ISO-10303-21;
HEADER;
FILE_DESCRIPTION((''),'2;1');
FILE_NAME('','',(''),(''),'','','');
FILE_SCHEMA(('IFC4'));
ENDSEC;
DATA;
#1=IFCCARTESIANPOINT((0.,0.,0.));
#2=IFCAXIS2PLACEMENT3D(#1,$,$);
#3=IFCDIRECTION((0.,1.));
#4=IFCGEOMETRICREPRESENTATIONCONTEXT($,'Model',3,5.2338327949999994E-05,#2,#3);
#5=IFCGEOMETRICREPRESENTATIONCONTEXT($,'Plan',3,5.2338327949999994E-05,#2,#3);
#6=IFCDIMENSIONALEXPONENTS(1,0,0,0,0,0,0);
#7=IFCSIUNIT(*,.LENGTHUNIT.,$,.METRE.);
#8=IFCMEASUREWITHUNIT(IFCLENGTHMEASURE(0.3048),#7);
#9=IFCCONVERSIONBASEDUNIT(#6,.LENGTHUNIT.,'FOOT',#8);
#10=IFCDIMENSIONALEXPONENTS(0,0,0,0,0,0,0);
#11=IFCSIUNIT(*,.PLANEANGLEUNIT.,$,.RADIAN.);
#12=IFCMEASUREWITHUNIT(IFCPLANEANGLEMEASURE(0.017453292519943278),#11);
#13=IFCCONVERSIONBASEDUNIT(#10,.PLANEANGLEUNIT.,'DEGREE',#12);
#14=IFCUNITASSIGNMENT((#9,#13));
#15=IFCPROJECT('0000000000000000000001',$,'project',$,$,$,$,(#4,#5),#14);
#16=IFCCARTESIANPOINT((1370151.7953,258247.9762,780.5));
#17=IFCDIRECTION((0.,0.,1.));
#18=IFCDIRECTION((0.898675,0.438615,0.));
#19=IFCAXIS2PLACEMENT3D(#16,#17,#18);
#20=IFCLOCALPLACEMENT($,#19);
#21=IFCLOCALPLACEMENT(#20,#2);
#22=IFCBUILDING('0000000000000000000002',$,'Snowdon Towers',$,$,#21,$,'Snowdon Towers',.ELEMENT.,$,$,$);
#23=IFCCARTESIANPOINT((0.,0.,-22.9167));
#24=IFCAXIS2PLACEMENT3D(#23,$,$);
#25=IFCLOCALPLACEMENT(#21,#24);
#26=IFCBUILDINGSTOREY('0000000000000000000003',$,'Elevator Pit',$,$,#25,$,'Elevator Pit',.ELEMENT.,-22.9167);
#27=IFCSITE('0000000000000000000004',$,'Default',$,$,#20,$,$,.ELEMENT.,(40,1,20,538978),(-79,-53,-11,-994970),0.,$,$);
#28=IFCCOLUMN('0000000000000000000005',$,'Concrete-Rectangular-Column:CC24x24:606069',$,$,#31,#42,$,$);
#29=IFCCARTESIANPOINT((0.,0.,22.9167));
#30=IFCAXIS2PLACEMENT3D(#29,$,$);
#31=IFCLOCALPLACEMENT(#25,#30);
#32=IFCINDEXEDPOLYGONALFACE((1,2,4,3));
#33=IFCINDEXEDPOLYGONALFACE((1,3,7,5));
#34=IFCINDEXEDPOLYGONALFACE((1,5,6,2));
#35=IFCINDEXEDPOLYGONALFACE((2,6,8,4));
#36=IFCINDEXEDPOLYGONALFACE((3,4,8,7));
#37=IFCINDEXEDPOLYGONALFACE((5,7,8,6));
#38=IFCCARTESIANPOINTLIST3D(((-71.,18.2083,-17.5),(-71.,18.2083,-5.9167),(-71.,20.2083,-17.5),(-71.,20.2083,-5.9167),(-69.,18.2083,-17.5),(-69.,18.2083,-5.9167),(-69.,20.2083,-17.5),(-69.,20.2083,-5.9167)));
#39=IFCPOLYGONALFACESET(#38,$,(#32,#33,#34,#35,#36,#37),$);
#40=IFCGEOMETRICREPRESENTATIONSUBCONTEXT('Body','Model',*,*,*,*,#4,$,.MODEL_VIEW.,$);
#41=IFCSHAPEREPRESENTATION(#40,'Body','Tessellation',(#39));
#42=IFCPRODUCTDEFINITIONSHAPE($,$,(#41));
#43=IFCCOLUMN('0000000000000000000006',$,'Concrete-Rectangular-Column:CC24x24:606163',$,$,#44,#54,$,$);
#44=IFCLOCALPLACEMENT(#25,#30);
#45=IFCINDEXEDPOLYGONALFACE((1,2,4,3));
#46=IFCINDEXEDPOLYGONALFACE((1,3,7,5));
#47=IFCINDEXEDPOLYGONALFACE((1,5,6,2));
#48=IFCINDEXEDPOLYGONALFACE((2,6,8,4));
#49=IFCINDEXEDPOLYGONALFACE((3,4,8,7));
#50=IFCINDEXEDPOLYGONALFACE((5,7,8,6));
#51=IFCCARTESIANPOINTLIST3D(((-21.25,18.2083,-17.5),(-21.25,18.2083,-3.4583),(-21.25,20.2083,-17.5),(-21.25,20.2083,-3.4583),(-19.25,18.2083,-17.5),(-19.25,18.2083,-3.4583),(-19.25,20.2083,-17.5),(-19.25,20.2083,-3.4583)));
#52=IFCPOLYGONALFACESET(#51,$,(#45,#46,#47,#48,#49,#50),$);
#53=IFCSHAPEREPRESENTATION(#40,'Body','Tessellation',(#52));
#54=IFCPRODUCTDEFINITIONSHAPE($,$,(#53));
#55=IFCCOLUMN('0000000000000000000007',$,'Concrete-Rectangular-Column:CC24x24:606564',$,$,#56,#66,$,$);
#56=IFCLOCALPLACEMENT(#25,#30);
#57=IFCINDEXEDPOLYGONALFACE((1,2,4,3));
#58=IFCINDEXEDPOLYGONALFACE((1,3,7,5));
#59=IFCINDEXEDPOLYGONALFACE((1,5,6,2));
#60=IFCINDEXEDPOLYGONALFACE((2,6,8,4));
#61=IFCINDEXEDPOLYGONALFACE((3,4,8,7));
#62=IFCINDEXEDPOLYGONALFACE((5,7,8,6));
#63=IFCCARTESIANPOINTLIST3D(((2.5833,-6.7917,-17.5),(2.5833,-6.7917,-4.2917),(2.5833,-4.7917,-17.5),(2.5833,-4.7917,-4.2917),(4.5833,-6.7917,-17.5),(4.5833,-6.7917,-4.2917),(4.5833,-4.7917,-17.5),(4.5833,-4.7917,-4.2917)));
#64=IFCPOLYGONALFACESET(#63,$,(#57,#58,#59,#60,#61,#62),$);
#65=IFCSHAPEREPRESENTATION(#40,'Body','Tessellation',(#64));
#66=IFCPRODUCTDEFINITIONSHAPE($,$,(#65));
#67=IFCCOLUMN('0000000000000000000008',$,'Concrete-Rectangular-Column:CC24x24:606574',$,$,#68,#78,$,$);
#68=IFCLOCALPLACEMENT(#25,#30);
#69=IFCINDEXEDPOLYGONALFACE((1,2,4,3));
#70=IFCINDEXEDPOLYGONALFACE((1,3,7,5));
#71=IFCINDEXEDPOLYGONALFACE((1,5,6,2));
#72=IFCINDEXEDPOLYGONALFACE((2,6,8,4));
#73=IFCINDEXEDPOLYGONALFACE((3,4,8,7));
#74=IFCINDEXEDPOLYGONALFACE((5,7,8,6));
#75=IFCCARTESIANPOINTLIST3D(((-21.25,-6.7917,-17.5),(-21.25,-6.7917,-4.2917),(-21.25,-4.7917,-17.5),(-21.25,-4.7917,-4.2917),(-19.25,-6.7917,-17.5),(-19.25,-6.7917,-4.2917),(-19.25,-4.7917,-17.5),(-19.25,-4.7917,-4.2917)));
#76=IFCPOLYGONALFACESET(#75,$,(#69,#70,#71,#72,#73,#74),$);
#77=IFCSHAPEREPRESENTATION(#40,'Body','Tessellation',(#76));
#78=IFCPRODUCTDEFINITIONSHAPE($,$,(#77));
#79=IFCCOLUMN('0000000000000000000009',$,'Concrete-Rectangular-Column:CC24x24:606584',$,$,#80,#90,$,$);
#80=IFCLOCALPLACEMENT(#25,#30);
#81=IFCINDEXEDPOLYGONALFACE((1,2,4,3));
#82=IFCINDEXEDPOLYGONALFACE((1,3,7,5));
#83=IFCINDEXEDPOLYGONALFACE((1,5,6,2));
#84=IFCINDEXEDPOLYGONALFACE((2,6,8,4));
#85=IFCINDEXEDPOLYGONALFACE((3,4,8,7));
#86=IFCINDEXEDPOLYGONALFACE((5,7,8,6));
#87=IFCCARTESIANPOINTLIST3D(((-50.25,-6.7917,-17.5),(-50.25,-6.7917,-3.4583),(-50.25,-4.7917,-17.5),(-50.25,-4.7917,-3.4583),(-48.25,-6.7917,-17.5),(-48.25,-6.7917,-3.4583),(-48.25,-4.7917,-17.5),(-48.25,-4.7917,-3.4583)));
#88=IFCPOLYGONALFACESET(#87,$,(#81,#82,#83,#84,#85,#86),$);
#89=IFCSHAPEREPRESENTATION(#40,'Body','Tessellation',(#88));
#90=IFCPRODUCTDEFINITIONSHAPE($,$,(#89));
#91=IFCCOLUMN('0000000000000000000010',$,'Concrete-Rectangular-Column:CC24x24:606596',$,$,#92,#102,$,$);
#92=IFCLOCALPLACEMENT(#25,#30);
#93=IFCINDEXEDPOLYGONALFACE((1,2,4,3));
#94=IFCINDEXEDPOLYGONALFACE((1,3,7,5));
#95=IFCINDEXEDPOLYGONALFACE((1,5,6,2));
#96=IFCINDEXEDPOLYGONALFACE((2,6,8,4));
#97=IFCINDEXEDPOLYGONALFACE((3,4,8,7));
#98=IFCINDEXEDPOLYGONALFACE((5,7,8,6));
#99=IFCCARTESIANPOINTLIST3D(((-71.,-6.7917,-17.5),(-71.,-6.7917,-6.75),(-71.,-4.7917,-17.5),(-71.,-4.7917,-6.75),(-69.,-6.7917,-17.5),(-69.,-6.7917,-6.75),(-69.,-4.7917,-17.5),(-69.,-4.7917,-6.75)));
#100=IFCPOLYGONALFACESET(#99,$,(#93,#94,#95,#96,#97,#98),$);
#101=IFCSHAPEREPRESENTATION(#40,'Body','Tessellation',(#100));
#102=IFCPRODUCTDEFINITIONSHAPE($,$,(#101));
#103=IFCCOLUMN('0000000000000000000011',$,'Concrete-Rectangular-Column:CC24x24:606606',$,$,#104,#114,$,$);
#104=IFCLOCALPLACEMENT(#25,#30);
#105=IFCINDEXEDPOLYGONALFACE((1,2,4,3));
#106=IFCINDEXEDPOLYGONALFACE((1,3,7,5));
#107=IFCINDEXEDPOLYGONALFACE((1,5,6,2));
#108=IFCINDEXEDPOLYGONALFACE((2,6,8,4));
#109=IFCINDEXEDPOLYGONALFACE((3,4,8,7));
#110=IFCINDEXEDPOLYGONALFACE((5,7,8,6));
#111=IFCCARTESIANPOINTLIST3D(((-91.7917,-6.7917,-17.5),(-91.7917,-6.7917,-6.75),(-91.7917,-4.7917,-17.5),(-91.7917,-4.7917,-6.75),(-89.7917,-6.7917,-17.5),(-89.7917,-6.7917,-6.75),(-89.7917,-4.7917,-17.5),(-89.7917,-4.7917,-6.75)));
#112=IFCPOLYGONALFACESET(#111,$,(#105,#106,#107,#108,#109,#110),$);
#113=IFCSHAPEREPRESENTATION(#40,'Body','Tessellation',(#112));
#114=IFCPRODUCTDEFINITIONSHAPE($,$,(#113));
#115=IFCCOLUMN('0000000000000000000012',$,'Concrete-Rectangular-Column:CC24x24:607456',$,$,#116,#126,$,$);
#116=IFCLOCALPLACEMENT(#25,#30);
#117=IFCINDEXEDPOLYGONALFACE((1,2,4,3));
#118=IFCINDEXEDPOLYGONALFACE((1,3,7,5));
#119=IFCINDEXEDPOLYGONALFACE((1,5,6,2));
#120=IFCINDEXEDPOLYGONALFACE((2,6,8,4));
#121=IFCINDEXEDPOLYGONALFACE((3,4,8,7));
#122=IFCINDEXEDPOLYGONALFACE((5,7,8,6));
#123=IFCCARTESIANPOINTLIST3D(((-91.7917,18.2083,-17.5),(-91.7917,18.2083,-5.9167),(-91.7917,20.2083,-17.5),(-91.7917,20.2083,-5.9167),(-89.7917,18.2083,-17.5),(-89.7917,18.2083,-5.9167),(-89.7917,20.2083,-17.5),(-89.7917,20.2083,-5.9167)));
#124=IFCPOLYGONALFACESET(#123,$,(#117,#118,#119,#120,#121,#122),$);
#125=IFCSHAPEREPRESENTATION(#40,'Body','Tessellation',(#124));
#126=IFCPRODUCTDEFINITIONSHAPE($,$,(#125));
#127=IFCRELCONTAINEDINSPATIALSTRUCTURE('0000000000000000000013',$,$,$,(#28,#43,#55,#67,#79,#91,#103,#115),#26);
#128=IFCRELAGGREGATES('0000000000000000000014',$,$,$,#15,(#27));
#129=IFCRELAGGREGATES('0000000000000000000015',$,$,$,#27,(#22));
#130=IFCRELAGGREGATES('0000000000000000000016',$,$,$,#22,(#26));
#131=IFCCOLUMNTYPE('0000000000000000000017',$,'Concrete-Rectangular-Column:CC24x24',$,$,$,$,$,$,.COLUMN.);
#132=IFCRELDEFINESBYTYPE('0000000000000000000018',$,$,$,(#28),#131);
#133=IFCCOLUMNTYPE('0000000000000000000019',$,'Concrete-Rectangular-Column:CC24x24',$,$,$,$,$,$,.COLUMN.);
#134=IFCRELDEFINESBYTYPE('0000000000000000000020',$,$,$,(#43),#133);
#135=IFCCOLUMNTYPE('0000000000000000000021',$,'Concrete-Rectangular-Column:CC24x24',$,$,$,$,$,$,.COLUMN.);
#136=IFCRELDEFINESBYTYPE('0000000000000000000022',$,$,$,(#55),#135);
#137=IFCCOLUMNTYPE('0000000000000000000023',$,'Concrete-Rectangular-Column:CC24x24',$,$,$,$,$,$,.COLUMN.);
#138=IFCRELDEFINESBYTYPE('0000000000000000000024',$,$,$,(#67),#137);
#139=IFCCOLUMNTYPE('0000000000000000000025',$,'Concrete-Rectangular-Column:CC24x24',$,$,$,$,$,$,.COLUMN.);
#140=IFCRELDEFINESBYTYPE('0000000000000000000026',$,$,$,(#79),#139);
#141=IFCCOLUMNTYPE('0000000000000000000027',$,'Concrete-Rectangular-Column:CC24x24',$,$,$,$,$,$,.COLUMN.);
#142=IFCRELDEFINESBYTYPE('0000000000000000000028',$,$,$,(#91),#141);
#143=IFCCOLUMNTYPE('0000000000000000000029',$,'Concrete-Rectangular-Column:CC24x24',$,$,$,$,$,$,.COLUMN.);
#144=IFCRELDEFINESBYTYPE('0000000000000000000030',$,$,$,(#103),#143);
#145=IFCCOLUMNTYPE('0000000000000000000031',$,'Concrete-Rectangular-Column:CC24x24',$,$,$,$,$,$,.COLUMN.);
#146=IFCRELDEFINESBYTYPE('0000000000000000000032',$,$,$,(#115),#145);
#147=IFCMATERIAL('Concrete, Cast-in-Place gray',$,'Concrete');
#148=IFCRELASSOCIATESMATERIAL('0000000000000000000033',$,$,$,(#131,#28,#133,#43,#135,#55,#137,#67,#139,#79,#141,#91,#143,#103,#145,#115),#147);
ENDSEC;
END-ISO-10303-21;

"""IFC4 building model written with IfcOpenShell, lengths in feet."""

from ifc_helpers import new_model, entity, si_unit, converted_unit, direction, frame, origin, place, context, subcontext, project, spatial, indexed_curve, outline, extrude, source, transform, mapped, material, type_object, type_shapes, element, save


model = new_model("IFC4")

# Units and contexts
model_context = context("Model", 3, precision=5.2338327949999994e-05, world=origin(), true_north=direction((0.0, 1.0)))
plan_context = context("Plan", 3, precision=5.2338327949999994e-05, world=origin(), true_north=direction((0.0, 1.0)))
body_context = subcontext(model_context, "Body", "Model", "MODEL_VIEW")
ifc_project = project(units=[converted_unit("LENGTHUNIT", "FOOT", entity("IfcLengthMeasure", 0.3048), si_unit("LENGTHUNIT", "METRE"), dimensions=[1, 0, 0, 0, 0, 0, 0]), converted_unit("PLANEANGLEUNIT", "DEGREE", entity("IfcPlaneAngleMeasure", 0.017453292519943278), si_unit("PLANEANGLEUNIT", "RADIAN"), dimensions=[0, 0, 0, 0, 0, 0, 0])], contexts=[model_context, plan_context])

# Site, building, storey
site_placement = place(None, frame((1370151.7953, 258247.9762, 780.5), z_axis=(0.0, 0.0, 1.0), x_axis=(0.898675, 0.438615, 0.0)))
site = spatial("IfcSite", under=ifc_project, at=site_placement, Name="Default", CompositionType="ELEMENT", RefLatitude=(40, 1, 20, 538978), RefLongitude=(-79, -53, -11, -994970), RefElevation=0.0)
building_placement = place(site_placement, origin())
building = spatial("IfcBuilding", under=site, at=building_placement, Name="Snowdon Towers", LongName="Snowdon Towers", CompositionType="ELEMENT")
storey_placement = place(building_placement, frame((0.0, 0.0, -22.9167)))
storey = spatial("IfcBuildingStorey", under=building, at=storey_placement, Name="Elevator Pit", LongName="Elevator Pit", CompositionType="ELEMENT", Elevation=-22.9167)

# Columns
ifc_material = material(Name="Concrete, Cast-in-Place gray", Category="Concrete")
column_type_1 = type_object("IfcColumnType", Name="Concrete-Rectangular-Column:CC24x24", PredefinedType="COLUMN", material=ifc_material)
shared_shape_1 = source(origin(), body_context, "Body", "SweptSolid", [
    extrude(outline(indexed_curve([(-1.0, -1.0), (1.0, -1.0), (1.0, 1.0), (-1.0, 1.0), (-1.0, -1.0)], self_intersect=False)), frame((-70.0, 19.2083, -17.5), z_axis=(0.0, 0.0, 1.0), x_axis=(-1.0, 0.0, 0.0)), (0.0, 0.0, 1.0), 11.5833),
])
type_shapes(column_type_1, [shared_shape_1])
column_1_placement = place(storey_placement, frame((0.0, 0.0, 22.9167)))
element("IfcColumn", 1, at=column_1_placement, inside=storey, type_object=column_type_1, material=ifc_material, Name="Concrete-Rectangular-Column:CC24x24:606069", context=body_context, shape_type="MappedRepresentation", body=[
    mapped(shared_shape_1, transform((0.0, 0.0, 0.0), scale=1.0)),
])
column_type_2 = type_object("IfcColumnType", Name="Concrete-Rectangular-Column:CC24x24", PredefinedType="COLUMN", material=ifc_material)
shared_shape_2 = source(origin(), body_context, "Body", "SweptSolid", [
    extrude(outline(indexed_curve([(-1.0, -1.0), (1.0, -1.0), (1.0, 1.0), (-1.0, 1.0), (-1.0, -1.0)], self_intersect=False)), frame((-20.25, 19.2083, -17.5), z_axis=(0.0, 0.0, 1.0), x_axis=(-1.0, 0.0, 0.0)), (0.0, 0.0, 1.0), 14.0417),
])
type_shapes(column_type_2, [shared_shape_2])
column_2_placement = place(storey_placement, frame((0.0, 0.0, 22.9167)))
element("IfcColumn", 2, at=column_2_placement, inside=storey, type_object=column_type_2, material=ifc_material, Name="Concrete-Rectangular-Column:CC24x24:606163", context=body_context, shape_type="MappedRepresentation", body=[
    mapped(shared_shape_2, transform((0.0, 0.0, 0.0), scale=1.0)),
])
column_type_3 = type_object("IfcColumnType", Name="Concrete-Rectangular-Column:CC24x24", PredefinedType="COLUMN", material=ifc_material)
shared_shape_3 = source(origin(), body_context, "Body", "SweptSolid", [
    extrude(outline(indexed_curve([(-1.0, -1.0), (1.0, -1.0), (1.0, 1.0), (-1.0, 1.0), (-1.0, -1.0)], self_intersect=False)), frame((3.5833, -5.7917, -17.5), z_axis=(0.0, 0.0, 1.0), x_axis=(-1.0, 0.0, 0.0)), (0.0, 0.0, 1.0), 13.2083),
])
type_shapes(column_type_3, [shared_shape_3])
column_3_placement = place(storey_placement, frame((0.0, 0.0, 22.9167)))
element("IfcColumn", 3, at=column_3_placement, inside=storey, type_object=column_type_3, material=ifc_material, Name="Concrete-Rectangular-Column:CC24x24:606564", context=body_context, shape_type="MappedRepresentation", body=[
    mapped(shared_shape_3, transform((0.0, 0.0, 0.0), scale=1.0)),
])
column_type_4 = type_object("IfcColumnType", Name="Concrete-Rectangular-Column:CC24x24", PredefinedType="COLUMN", material=ifc_material)
shared_shape_4 = source(origin(), body_context, "Body", "SweptSolid", [
    extrude(outline(indexed_curve([(-1.0, -1.0), (1.0, -1.0), (1.0, 1.0), (-1.0, 1.0), (-1.0, -1.0)], self_intersect=False)), frame((-20.25, -5.7917, -17.5), z_axis=(0.0, 0.0, 1.0), x_axis=(-1.0, 0.0, 0.0)), (0.0, 0.0, 1.0), 13.2083),
])
type_shapes(column_type_4, [shared_shape_4])
column_4_placement = place(storey_placement, frame((0.0, 0.0, 22.9167)))
element("IfcColumn", 4, at=column_4_placement, inside=storey, type_object=column_type_4, material=ifc_material, Name="Concrete-Rectangular-Column:CC24x24:606574", context=body_context, shape_type="MappedRepresentation", body=[
    mapped(shared_shape_4, transform((0.0, 0.0, 0.0), scale=1.0)),
])
column_type_5 = type_object("IfcColumnType", Name="Concrete-Rectangular-Column:CC24x24", PredefinedType="COLUMN", material=ifc_material)
shared_shape_5 = source(origin(), body_context, "Body", "SweptSolid", [
    extrude(outline(indexed_curve([(-1.0, -1.0), (1.0, -1.0), (1.0, 1.0), (-1.0, 1.0), (-1.0, -1.0)], self_intersect=False)), frame((-49.25, -5.7917, -17.5), z_axis=(0.0, 0.0, 1.0), x_axis=(-1.0, 0.0, 0.0)), (0.0, 0.0, 1.0), 14.0417),
])
type_shapes(column_type_5, [shared_shape_5])
column_5_placement = place(storey_placement, frame((0.0, 0.0, 22.9167)))
element("IfcColumn", 5, at=column_5_placement, inside=storey, type_object=column_type_5, material=ifc_material, Name="Concrete-Rectangular-Column:CC24x24:606584", context=body_context, shape_type="MappedRepresentation", body=[
    mapped(shared_shape_5, transform((0.0, 0.0, 0.0), scale=1.0)),
])
column_type_6 = type_object("IfcColumnType", Name="Concrete-Rectangular-Column:CC24x24", PredefinedType="COLUMN", material=ifc_material)
shared_shape_6 = source(origin(), body_context, "Body", "SweptSolid", [
    extrude(outline(indexed_curve([(-1.0, -1.0), (1.0, -1.0), (1.0, 1.0), (-1.0, 1.0), (-1.0, -1.0)], self_intersect=False)), frame((-70.0, -5.7917, -17.5), z_axis=(0.0, 0.0, 1.0), x_axis=(-1.0, 0.0, 0.0)), (0.0, 0.0, 1.0), 10.75),
])
type_shapes(column_type_6, [shared_shape_6])
column_6_placement = place(storey_placement, frame((0.0, 0.0, 22.9167)))
element("IfcColumn", 6, at=column_6_placement, inside=storey, type_object=column_type_6, material=ifc_material, Name="Concrete-Rectangular-Column:CC24x24:606596", context=body_context, shape_type="MappedRepresentation", body=[
    mapped(shared_shape_6, transform((0.0, 0.0, 0.0), scale=1.0)),
])
column_type_7 = type_object("IfcColumnType", Name="Concrete-Rectangular-Column:CC24x24", PredefinedType="COLUMN", material=ifc_material)
shared_shape_7 = source(origin(), body_context, "Body", "SweptSolid", [
    extrude(outline(indexed_curve([(-1.0, -1.0), (1.0, -1.0), (1.0, 1.0), (-1.0, 1.0), (-1.0, -1.0)], self_intersect=False)), frame((-90.7917, -5.7917, -17.5), z_axis=(0.0, 0.0, 1.0), x_axis=(-1.0, 0.0, 0.0)), (0.0, 0.0, 1.0), 10.75),
])
type_shapes(column_type_7, [shared_shape_7])
column_7_placement = place(storey_placement, frame((0.0, 0.0, 22.9167)))
element("IfcColumn", 7, at=column_7_placement, inside=storey, type_object=column_type_7, material=ifc_material, Name="Concrete-Rectangular-Column:CC24x24:606606", context=body_context, shape_type="MappedRepresentation", body=[
    mapped(shared_shape_7, transform((0.0, 0.0, 0.0), scale=1.0)),
])
column_type_8 = type_object("IfcColumnType", Name="Concrete-Rectangular-Column:CC24x24", PredefinedType="COLUMN", material=ifc_material)
shared_shape_8 = source(origin(), body_context, "Body", "SweptSolid", [
    extrude(outline(indexed_curve([(-1.0, -1.0), (1.0, -1.0), (1.0, 1.0), (-1.0, 1.0), (-1.0, -1.0)], self_intersect=False)), frame((-90.7917, 19.2083, -17.5), z_axis=(0.0, 0.0, 1.0), x_axis=(-1.0, 0.0, 0.0)), (0.0, 0.0, 1.0), 11.5833),
])
type_shapes(column_type_8, [shared_shape_8])
column_8_placement = place(storey_placement, frame((0.0, 0.0, 22.9167)))
element("IfcColumn", 8, at=column_8_placement, inside=storey, type_object=column_type_8, material=ifc_material, Name="Concrete-Rectangular-Column:CC24x24:607456", context=body_context, shape_type="MappedRepresentation", body=[
    mapped(shared_shape_8, transform((0.0, 0.0, 0.0), scale=1.0)),
])

save(model, "model.ifc")
